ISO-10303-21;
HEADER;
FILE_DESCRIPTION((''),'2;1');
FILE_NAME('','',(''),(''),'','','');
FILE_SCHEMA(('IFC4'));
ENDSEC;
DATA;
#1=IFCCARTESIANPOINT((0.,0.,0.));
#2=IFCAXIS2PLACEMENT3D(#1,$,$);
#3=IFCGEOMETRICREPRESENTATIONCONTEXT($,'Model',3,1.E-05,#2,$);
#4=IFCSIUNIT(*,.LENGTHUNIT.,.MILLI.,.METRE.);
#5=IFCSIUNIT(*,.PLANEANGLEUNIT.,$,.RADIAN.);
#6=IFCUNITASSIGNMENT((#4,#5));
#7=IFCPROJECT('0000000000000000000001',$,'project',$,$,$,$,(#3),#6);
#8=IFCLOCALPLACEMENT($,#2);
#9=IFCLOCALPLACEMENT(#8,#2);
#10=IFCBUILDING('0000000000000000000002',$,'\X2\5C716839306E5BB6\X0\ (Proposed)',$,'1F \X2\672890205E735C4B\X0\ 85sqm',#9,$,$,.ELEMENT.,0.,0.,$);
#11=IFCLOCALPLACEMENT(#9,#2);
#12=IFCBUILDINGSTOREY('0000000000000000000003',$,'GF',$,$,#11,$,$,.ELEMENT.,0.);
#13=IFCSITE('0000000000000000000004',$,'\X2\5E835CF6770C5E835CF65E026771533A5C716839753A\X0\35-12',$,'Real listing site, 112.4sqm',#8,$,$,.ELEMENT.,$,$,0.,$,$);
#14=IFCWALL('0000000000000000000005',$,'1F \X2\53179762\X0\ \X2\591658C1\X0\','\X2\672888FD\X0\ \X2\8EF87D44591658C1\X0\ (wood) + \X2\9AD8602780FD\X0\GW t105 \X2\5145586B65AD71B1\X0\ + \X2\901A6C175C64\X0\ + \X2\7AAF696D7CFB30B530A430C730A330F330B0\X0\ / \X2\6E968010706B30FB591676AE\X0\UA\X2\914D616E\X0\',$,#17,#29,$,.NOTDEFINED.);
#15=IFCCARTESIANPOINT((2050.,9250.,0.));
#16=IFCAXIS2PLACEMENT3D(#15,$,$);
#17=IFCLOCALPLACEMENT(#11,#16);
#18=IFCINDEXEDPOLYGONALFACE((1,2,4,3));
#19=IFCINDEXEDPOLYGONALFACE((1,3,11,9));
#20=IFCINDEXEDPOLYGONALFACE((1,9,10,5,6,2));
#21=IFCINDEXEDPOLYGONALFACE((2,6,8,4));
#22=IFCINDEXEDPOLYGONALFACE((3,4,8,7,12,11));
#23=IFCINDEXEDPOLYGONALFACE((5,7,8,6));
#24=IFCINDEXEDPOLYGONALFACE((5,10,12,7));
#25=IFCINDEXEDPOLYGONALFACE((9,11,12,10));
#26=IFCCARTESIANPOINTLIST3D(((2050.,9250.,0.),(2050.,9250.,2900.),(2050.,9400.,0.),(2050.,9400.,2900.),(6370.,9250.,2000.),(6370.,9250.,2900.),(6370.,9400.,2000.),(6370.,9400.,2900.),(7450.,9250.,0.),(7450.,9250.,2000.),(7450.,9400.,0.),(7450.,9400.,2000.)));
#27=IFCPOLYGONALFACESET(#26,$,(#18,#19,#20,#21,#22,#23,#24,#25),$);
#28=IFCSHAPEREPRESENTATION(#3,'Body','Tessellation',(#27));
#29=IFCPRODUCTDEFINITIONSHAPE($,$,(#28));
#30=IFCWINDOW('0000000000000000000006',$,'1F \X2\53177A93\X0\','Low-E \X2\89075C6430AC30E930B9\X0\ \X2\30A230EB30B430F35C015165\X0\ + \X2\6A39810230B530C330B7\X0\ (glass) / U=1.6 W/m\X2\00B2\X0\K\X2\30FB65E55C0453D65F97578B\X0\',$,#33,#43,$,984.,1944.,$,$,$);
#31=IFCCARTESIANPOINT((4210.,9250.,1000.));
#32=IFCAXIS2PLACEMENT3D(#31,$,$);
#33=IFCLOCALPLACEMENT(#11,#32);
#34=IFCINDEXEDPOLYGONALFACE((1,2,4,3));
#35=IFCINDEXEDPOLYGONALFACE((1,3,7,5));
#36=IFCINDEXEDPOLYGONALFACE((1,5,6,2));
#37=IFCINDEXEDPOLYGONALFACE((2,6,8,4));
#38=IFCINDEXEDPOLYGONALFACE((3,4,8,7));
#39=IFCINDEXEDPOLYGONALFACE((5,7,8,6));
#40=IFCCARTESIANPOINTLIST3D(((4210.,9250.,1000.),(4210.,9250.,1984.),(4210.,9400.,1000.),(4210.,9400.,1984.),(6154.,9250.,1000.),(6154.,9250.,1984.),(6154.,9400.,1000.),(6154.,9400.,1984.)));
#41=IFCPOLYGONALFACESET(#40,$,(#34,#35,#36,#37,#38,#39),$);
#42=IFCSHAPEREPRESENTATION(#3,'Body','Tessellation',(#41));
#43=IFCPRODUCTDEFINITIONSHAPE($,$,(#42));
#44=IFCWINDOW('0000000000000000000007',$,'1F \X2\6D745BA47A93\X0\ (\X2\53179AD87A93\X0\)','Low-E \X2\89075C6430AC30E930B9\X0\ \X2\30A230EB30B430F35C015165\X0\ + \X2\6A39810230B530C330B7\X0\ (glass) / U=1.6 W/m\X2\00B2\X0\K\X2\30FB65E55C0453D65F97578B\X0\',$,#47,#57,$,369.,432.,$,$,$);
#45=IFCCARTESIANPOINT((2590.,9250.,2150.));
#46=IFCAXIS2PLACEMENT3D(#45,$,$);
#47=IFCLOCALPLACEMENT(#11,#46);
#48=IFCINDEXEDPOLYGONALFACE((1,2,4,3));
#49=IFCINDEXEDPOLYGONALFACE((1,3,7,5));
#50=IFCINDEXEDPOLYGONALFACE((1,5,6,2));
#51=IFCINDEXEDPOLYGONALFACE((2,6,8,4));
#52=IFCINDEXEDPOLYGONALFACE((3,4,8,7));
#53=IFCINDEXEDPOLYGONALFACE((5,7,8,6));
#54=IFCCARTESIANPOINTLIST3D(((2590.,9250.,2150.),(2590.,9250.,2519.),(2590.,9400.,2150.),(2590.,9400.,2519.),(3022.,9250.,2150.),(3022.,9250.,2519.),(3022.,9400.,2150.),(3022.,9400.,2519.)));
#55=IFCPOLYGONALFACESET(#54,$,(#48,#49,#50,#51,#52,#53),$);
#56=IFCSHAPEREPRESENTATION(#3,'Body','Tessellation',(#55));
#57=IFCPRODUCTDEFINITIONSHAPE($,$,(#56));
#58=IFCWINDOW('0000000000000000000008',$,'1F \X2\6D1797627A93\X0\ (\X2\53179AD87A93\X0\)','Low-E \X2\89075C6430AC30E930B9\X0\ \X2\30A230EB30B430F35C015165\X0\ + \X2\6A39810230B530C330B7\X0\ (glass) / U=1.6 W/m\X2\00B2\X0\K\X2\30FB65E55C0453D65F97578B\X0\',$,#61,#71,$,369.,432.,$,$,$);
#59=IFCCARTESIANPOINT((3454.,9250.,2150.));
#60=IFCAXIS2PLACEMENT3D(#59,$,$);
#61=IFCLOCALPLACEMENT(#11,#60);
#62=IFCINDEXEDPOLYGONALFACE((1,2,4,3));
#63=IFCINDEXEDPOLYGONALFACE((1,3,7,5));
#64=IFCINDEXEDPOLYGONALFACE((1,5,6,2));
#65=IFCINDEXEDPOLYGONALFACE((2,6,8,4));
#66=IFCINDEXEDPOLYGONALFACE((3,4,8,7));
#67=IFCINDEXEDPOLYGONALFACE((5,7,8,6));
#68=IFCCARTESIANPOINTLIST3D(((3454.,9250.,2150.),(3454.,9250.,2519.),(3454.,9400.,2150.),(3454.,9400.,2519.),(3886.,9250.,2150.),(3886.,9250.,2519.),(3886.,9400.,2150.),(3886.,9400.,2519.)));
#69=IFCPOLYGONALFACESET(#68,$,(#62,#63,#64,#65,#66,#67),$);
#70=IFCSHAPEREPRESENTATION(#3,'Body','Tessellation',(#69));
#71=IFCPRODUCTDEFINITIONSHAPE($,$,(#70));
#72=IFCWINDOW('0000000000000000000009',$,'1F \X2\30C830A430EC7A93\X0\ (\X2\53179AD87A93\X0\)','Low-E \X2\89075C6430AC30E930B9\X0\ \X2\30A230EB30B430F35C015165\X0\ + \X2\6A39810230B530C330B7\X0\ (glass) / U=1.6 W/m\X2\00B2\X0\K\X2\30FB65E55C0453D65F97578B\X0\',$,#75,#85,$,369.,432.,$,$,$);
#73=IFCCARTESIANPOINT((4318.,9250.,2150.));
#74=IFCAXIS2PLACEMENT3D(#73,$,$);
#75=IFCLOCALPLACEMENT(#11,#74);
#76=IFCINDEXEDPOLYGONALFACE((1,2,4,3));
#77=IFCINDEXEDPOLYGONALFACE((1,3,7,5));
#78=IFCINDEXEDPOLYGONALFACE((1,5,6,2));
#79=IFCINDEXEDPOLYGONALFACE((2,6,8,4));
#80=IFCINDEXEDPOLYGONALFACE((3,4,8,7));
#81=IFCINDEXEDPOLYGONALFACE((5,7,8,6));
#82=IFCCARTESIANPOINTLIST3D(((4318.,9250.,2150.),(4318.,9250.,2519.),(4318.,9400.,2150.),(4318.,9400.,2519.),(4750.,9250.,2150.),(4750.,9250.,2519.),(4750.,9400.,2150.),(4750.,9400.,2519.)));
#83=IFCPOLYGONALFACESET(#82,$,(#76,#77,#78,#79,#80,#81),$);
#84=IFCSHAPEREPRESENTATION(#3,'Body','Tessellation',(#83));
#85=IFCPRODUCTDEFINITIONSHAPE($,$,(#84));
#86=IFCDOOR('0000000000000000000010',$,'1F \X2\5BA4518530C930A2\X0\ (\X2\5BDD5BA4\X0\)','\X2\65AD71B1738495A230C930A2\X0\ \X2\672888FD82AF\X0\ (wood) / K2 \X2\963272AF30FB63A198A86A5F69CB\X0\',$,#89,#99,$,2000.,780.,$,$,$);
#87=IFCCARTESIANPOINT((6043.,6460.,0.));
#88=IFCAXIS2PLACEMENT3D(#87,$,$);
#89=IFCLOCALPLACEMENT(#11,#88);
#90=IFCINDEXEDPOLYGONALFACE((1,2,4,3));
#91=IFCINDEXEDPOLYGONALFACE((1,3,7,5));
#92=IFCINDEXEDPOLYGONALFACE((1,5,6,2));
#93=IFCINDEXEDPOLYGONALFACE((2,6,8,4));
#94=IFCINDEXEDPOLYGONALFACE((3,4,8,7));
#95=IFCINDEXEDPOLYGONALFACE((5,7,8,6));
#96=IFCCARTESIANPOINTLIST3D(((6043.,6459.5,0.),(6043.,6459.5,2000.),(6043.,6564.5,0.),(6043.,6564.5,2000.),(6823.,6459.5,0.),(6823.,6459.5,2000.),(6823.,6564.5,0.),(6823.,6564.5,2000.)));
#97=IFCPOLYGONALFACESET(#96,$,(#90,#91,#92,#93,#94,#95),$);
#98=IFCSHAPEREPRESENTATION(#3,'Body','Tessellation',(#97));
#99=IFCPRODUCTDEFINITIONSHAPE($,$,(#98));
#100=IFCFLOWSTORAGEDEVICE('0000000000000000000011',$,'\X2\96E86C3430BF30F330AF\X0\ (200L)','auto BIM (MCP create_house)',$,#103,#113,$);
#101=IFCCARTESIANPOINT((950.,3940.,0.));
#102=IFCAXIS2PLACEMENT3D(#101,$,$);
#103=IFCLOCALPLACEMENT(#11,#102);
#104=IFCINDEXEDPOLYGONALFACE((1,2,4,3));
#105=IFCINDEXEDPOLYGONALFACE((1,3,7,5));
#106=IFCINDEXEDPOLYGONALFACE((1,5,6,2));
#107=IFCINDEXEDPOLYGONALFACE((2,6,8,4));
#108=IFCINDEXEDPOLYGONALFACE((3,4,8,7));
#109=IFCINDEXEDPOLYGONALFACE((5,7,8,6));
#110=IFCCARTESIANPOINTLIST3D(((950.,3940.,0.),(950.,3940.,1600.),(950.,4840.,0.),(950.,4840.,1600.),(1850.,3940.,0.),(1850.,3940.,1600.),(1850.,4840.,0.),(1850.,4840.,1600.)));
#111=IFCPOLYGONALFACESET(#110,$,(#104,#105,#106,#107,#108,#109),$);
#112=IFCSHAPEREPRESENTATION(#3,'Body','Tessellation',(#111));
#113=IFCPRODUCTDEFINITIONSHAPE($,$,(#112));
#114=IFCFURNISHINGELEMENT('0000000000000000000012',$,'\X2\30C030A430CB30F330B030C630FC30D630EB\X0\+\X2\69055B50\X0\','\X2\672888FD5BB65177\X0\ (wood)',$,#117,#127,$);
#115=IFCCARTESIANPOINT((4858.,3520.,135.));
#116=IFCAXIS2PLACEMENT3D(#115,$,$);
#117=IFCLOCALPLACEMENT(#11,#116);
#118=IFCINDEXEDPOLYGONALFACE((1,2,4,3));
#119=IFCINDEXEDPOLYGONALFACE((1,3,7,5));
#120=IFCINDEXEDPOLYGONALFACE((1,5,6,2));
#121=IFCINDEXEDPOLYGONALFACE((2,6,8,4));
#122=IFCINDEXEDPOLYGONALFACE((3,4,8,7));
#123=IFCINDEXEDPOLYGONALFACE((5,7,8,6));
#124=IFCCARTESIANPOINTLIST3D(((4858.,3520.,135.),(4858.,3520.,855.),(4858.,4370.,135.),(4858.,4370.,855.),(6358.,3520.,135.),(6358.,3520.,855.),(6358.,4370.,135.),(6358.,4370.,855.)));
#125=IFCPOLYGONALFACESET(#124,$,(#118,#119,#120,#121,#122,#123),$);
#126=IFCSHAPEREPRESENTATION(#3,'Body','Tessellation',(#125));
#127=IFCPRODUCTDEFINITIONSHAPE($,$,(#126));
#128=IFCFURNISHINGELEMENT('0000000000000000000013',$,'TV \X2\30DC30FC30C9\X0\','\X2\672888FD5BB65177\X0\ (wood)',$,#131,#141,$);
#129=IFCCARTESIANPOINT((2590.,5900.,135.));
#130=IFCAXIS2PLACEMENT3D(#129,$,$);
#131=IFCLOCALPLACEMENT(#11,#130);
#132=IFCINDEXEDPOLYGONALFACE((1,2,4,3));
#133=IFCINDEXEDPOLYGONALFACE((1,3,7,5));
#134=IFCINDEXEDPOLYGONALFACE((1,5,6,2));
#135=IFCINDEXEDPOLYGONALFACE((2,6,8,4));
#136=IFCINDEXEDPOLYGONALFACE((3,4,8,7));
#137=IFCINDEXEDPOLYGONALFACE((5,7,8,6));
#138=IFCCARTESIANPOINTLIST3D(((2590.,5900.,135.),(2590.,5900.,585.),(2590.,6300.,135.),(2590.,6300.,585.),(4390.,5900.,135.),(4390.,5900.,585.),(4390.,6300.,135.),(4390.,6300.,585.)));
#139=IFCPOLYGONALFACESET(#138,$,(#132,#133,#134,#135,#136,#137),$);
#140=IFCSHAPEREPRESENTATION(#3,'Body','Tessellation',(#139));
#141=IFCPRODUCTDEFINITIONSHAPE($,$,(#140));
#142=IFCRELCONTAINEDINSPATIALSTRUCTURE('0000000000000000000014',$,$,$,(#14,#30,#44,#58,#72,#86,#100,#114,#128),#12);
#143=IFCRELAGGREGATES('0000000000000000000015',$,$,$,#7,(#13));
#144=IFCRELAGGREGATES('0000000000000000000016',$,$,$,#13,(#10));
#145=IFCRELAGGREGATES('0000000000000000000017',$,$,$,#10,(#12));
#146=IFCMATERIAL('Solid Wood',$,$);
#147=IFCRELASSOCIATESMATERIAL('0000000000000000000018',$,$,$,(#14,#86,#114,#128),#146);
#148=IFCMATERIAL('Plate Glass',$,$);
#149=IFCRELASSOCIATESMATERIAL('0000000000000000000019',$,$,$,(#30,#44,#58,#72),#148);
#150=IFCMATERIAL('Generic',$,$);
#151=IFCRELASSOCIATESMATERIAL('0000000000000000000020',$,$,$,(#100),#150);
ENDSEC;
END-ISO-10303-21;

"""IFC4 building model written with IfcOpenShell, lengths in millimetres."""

from ifc_helpers import new_model, si_unit, frame, frame_2d, origin, place, context, project, spatial, rectangle, extrude, material, element, fill, save


model = new_model("IFC4")

# Units and contexts
model_context = context("Model", 3, precision=1e-05, world=origin())
ifc_project = project(units=[si_unit("LENGTHUNIT", "METRE", prefix="MILLI"), si_unit("PLANEANGLEUNIT", "RADIAN")], contexts=[model_context])

# Site, building, storey
site_placement = place(None, origin())
site = spatial("IfcSite", under=ifc_project, at=site_placement, Name="広島県広島市東区山根町35-12", ObjectType="Real listing site, 112.4sqm", CompositionType="ELEMENT", RefElevation=0.0)
building_placement = place(site_placement, origin())
building = spatial("IfcBuilding", under=site, at=building_placement, Name="山根の家 (Proposed)", ObjectType="1F 木造平屋 85sqm", CompositionType="ELEMENT", ElevationOfRefHeight=0.0, ElevationOfTerrain=0.0)
storey_placement = place(building_placement, origin())
storey = spatial("IfcBuildingStorey", under=building, at=storey_placement, Name="GF", CompositionType="ELEMENT", Elevation=0.0)

# Wall, openings, windows
ifc_material_1 = material(Name="Solid Wood")
wall_1_placement = place(storey_placement, frame((2050.0, 9250.0, 0.0)))
wall_1 = element("IfcWall", 1, at=wall_1_placement, inside=storey, material=ifc_material_1, Name="1F 北面 外壁", Description="木製 軸組外壁 (wood) + 高性能GW t105 充填断熱 + 通気層 + 窯業系サイディング / 準耐火・外皮UA配慮", PredefinedType="NOTDEFINED", context=model_context, shape_type="SweptSolid", body=[
    extrude(rectangle(XDim=5400.0, YDim=150.0, at=frame_2d((2700.0, 75.0))), frame((2050.0, 9250.0, 0.0)), (0.0, 0.0, 1.0), 2900.0),
])
opening_1_placement = place(storey_placement, frame((4210.0, 9250.0, 1000.0)))
opening_1 = element("IfcOpeningElement", 2, at=opening_1_placement, cuts=wall_1, PredefinedType="NOTDEFINED", context=model_context, shape_type="SweptSolid", body=[
    extrude(rectangle(XDim=1944.0, YDim=150.0, at=frame_2d((972.0, 75.0))), frame((4210.0, 9250.0, 1000.0)), (0.0, 0.0, 1.0), 984.0),
])
opening_2_placement = place(storey_placement, frame((2590.0, 9250.0, 2150.0)))
opening_2 = element("IfcOpeningElement", 3, at=opening_2_placement, cuts=wall_1, PredefinedType="NOTDEFINED", context=model_context, shape_type="SweptSolid", body=[
    extrude(rectangle(XDim=432.0, YDim=150.0, at=frame_2d((216.0, 75.0))), frame((2590.0, 9250.0, 2150.0)), (0.0, 0.0, 1.0), 369.0),
])
opening_3_placement = place(storey_placement, frame((3454.0, 9250.0, 2150.0)))
opening_3 = element("IfcOpeningElement", 4, at=opening_3_placement, cuts=wall_1, PredefinedType="NOTDEFINED", context=model_context, shape_type="SweptSolid", body=[
    extrude(rectangle(XDim=432.0, YDim=150.0, at=frame_2d((216.0, 75.0))), frame((3454.0, 9250.0, 2150.0)), (0.0, 0.0, 1.0), 369.0),
])
opening_4_placement = place(storey_placement, frame((4318.0, 9250.0, 2150.0)))
opening_4 = element("IfcOpeningElement", 5, at=opening_4_placement, cuts=wall_1, PredefinedType="NOTDEFINED", context=model_context, shape_type="SweptSolid", body=[
    extrude(rectangle(XDim=432.0, YDim=150.0, at=frame_2d((216.0, 75.0))), frame((4318.0, 9250.0, 2150.0)), (0.0, 0.0, 1.0), 369.0),
])
ifc_material_2 = material(Name="Plate Glass")
window_1_placement = place(storey_placement, frame((4210.0, 9250.0, 1000.0)))
window_1 = element("IfcWindow", 6, at=window_1_placement, inside=storey, material=ifc_material_2, Name="1F 北窓", Description="Low-E 複層ガラス アルゴン封入 + 樹脂サッシ (glass) / U=1.6 W/m²K・日射取得型", OverallHeight=984.0, OverallWidth=1944.0, context=model_context, shape_type="SweptSolid", body=[
    extrude(rectangle(XDim=1944.0, YDim=150.0, at=frame_2d((972.0, 75.0))), frame((4210.0, 9250.0, 1000.0)), (0.0, 0.0, 1.0), 984.0),
])
fill(opening_1, window_1)
window_2_placement = place(storey_placement, frame((2590.0, 9250.0, 2150.0)))
window_2 = element("IfcWindow", 7, at=window_2_placement, inside=storey, material=ifc_material_2, Name="1F 浴室窓 (北高窓)", Description="Low-E 複層ガラス アルゴン封入 + 樹脂サッシ (glass) / U=1.6 W/m²K・日射取得型", OverallHeight=369.0, OverallWidth=432.0, context=model_context, shape_type="SweptSolid", body=[
    extrude(rectangle(XDim=432.0, YDim=150.0, at=frame_2d((216.0, 75.0))), frame((2590.0, 9250.0, 2150.0)), (0.0, 0.0, 1.0), 369.0),
])
fill(opening_2, window_2)
window_3_placement = place(storey_placement, frame((3454.0, 9250.0, 2150.0)))
window_3 = element("IfcWindow", 8, at=window_3_placement, inside=storey, material=ifc_material_2, Name="1F 洗面窓 (北高窓)", Description="Low-E 複層ガラス アルゴン封入 + 樹脂サッシ (glass) / U=1.6 W/m²K・日射取得型", OverallHeight=369.0, OverallWidth=432.0, context=model_context, shape_type="SweptSolid", body=[
    extrude(rectangle(XDim=432.0, YDim=150.0, at=frame_2d((216.0, 75.0))), frame((3454.0, 9250.0, 2150.0)), (0.0, 0.0, 1.0), 369.0),
])
fill(opening_3, window_3)
window_4_placement = place(storey_placement, frame((4318.0, 9250.0, 2150.0)))
window_4 = element("IfcWindow", 9, at=window_4_placement, inside=storey, material=ifc_material_2, Name="1F トイレ窓 (北高窓)", Description="Low-E 複層ガラス アルゴン封入 + 樹脂サッシ (glass) / U=1.6 W/m²K・日射取得型", OverallHeight=369.0, OverallWidth=432.0, context=model_context, shape_type="SweptSolid", body=[
    extrude(rectangle(XDim=432.0, YDim=150.0, at=frame_2d((216.0, 75.0))), frame((4318.0, 9250.0, 2150.0)), (0.0, 0.0, 1.0), 369.0),
])
fill(opening_4, window_4)

# Door
door_1_placement = place(storey_placement, frame((6043.0, 6460.0, 0.0)))
element("IfcDoor", 10, at=door_1_placement, inside=storey, material=ifc_material_1, Name="1F 室内ドア (寝室)", Description="断熱玄関ドア 木製芯 (wood) / K2 防犯・採風機構", OverallHeight=2000.0, OverallWidth=780.0, context=model_context, shape_type="SweptSolid", body=[
    extrude(rectangle(XDim=780.0, YDim=105.0, at=frame_2d((390.0, 52.0))), frame((6043.0, 6460.0, 0.0)), (0.0, 0.0, 1.0), 2000.0),
])

# Flow storage device
ifc_material_3 = material(Name="Generic")
flow_storage_device_placement = place(storey_placement, frame((950.0, 3940.0, 0.0)))
element("IfcFlowStorageDevice", 11, at=flow_storage_device_placement, inside=storey, material=ifc_material_3, Name="雨水タンク (200L)", Description="auto BIM (MCP create_house)", context=model_context, shape_type="SweptSolid", body=[
    extrude(rectangle(XDim=900.0, YDim=900.0, at=frame_2d((450.0, 450.0))), frame((950.0, 3940.0, 0.0)), (0.0, 0.0, 1.0), 1600.0),
])

# Furnishing elements
furnishing_1_placement = place(storey_placement, frame((4858.0, 3520.0, 135.0)))
element("IfcFurnishingElement", 12, at=furnishing_1_placement, inside=storey, material=ifc_material_1, Name="ダイニングテーブル+椅子", Description="木製家具 (wood)", context=model_context, shape_type="SweptSolid", body=[
    extrude(rectangle(XDim=1500.0, YDim=850.0, at=frame_2d((750.0, 425.0))), frame((4858.0, 3520.0, 135.0)), (0.0, 0.0, 1.0), 720.0),
])
furnishing_2_placement = place(storey_placement, frame((2590.0, 5900.0, 135.0)))
element("IfcFurnishingElement", 13, at=furnishing_2_placement, inside=storey, material=ifc_material_1, Name="TV ボード", Description="木製家具 (wood)", context=model_context, shape_type="SweptSolid", body=[
    extrude(rectangle(XDim=1800.0, YDim=400.0, at=frame_2d((900.0, 200.0))), frame((2590.0, 5900.0, 135.0)), (0.0, 0.0, 1.0), 450.0),
])

save(model, "model.ifc")
